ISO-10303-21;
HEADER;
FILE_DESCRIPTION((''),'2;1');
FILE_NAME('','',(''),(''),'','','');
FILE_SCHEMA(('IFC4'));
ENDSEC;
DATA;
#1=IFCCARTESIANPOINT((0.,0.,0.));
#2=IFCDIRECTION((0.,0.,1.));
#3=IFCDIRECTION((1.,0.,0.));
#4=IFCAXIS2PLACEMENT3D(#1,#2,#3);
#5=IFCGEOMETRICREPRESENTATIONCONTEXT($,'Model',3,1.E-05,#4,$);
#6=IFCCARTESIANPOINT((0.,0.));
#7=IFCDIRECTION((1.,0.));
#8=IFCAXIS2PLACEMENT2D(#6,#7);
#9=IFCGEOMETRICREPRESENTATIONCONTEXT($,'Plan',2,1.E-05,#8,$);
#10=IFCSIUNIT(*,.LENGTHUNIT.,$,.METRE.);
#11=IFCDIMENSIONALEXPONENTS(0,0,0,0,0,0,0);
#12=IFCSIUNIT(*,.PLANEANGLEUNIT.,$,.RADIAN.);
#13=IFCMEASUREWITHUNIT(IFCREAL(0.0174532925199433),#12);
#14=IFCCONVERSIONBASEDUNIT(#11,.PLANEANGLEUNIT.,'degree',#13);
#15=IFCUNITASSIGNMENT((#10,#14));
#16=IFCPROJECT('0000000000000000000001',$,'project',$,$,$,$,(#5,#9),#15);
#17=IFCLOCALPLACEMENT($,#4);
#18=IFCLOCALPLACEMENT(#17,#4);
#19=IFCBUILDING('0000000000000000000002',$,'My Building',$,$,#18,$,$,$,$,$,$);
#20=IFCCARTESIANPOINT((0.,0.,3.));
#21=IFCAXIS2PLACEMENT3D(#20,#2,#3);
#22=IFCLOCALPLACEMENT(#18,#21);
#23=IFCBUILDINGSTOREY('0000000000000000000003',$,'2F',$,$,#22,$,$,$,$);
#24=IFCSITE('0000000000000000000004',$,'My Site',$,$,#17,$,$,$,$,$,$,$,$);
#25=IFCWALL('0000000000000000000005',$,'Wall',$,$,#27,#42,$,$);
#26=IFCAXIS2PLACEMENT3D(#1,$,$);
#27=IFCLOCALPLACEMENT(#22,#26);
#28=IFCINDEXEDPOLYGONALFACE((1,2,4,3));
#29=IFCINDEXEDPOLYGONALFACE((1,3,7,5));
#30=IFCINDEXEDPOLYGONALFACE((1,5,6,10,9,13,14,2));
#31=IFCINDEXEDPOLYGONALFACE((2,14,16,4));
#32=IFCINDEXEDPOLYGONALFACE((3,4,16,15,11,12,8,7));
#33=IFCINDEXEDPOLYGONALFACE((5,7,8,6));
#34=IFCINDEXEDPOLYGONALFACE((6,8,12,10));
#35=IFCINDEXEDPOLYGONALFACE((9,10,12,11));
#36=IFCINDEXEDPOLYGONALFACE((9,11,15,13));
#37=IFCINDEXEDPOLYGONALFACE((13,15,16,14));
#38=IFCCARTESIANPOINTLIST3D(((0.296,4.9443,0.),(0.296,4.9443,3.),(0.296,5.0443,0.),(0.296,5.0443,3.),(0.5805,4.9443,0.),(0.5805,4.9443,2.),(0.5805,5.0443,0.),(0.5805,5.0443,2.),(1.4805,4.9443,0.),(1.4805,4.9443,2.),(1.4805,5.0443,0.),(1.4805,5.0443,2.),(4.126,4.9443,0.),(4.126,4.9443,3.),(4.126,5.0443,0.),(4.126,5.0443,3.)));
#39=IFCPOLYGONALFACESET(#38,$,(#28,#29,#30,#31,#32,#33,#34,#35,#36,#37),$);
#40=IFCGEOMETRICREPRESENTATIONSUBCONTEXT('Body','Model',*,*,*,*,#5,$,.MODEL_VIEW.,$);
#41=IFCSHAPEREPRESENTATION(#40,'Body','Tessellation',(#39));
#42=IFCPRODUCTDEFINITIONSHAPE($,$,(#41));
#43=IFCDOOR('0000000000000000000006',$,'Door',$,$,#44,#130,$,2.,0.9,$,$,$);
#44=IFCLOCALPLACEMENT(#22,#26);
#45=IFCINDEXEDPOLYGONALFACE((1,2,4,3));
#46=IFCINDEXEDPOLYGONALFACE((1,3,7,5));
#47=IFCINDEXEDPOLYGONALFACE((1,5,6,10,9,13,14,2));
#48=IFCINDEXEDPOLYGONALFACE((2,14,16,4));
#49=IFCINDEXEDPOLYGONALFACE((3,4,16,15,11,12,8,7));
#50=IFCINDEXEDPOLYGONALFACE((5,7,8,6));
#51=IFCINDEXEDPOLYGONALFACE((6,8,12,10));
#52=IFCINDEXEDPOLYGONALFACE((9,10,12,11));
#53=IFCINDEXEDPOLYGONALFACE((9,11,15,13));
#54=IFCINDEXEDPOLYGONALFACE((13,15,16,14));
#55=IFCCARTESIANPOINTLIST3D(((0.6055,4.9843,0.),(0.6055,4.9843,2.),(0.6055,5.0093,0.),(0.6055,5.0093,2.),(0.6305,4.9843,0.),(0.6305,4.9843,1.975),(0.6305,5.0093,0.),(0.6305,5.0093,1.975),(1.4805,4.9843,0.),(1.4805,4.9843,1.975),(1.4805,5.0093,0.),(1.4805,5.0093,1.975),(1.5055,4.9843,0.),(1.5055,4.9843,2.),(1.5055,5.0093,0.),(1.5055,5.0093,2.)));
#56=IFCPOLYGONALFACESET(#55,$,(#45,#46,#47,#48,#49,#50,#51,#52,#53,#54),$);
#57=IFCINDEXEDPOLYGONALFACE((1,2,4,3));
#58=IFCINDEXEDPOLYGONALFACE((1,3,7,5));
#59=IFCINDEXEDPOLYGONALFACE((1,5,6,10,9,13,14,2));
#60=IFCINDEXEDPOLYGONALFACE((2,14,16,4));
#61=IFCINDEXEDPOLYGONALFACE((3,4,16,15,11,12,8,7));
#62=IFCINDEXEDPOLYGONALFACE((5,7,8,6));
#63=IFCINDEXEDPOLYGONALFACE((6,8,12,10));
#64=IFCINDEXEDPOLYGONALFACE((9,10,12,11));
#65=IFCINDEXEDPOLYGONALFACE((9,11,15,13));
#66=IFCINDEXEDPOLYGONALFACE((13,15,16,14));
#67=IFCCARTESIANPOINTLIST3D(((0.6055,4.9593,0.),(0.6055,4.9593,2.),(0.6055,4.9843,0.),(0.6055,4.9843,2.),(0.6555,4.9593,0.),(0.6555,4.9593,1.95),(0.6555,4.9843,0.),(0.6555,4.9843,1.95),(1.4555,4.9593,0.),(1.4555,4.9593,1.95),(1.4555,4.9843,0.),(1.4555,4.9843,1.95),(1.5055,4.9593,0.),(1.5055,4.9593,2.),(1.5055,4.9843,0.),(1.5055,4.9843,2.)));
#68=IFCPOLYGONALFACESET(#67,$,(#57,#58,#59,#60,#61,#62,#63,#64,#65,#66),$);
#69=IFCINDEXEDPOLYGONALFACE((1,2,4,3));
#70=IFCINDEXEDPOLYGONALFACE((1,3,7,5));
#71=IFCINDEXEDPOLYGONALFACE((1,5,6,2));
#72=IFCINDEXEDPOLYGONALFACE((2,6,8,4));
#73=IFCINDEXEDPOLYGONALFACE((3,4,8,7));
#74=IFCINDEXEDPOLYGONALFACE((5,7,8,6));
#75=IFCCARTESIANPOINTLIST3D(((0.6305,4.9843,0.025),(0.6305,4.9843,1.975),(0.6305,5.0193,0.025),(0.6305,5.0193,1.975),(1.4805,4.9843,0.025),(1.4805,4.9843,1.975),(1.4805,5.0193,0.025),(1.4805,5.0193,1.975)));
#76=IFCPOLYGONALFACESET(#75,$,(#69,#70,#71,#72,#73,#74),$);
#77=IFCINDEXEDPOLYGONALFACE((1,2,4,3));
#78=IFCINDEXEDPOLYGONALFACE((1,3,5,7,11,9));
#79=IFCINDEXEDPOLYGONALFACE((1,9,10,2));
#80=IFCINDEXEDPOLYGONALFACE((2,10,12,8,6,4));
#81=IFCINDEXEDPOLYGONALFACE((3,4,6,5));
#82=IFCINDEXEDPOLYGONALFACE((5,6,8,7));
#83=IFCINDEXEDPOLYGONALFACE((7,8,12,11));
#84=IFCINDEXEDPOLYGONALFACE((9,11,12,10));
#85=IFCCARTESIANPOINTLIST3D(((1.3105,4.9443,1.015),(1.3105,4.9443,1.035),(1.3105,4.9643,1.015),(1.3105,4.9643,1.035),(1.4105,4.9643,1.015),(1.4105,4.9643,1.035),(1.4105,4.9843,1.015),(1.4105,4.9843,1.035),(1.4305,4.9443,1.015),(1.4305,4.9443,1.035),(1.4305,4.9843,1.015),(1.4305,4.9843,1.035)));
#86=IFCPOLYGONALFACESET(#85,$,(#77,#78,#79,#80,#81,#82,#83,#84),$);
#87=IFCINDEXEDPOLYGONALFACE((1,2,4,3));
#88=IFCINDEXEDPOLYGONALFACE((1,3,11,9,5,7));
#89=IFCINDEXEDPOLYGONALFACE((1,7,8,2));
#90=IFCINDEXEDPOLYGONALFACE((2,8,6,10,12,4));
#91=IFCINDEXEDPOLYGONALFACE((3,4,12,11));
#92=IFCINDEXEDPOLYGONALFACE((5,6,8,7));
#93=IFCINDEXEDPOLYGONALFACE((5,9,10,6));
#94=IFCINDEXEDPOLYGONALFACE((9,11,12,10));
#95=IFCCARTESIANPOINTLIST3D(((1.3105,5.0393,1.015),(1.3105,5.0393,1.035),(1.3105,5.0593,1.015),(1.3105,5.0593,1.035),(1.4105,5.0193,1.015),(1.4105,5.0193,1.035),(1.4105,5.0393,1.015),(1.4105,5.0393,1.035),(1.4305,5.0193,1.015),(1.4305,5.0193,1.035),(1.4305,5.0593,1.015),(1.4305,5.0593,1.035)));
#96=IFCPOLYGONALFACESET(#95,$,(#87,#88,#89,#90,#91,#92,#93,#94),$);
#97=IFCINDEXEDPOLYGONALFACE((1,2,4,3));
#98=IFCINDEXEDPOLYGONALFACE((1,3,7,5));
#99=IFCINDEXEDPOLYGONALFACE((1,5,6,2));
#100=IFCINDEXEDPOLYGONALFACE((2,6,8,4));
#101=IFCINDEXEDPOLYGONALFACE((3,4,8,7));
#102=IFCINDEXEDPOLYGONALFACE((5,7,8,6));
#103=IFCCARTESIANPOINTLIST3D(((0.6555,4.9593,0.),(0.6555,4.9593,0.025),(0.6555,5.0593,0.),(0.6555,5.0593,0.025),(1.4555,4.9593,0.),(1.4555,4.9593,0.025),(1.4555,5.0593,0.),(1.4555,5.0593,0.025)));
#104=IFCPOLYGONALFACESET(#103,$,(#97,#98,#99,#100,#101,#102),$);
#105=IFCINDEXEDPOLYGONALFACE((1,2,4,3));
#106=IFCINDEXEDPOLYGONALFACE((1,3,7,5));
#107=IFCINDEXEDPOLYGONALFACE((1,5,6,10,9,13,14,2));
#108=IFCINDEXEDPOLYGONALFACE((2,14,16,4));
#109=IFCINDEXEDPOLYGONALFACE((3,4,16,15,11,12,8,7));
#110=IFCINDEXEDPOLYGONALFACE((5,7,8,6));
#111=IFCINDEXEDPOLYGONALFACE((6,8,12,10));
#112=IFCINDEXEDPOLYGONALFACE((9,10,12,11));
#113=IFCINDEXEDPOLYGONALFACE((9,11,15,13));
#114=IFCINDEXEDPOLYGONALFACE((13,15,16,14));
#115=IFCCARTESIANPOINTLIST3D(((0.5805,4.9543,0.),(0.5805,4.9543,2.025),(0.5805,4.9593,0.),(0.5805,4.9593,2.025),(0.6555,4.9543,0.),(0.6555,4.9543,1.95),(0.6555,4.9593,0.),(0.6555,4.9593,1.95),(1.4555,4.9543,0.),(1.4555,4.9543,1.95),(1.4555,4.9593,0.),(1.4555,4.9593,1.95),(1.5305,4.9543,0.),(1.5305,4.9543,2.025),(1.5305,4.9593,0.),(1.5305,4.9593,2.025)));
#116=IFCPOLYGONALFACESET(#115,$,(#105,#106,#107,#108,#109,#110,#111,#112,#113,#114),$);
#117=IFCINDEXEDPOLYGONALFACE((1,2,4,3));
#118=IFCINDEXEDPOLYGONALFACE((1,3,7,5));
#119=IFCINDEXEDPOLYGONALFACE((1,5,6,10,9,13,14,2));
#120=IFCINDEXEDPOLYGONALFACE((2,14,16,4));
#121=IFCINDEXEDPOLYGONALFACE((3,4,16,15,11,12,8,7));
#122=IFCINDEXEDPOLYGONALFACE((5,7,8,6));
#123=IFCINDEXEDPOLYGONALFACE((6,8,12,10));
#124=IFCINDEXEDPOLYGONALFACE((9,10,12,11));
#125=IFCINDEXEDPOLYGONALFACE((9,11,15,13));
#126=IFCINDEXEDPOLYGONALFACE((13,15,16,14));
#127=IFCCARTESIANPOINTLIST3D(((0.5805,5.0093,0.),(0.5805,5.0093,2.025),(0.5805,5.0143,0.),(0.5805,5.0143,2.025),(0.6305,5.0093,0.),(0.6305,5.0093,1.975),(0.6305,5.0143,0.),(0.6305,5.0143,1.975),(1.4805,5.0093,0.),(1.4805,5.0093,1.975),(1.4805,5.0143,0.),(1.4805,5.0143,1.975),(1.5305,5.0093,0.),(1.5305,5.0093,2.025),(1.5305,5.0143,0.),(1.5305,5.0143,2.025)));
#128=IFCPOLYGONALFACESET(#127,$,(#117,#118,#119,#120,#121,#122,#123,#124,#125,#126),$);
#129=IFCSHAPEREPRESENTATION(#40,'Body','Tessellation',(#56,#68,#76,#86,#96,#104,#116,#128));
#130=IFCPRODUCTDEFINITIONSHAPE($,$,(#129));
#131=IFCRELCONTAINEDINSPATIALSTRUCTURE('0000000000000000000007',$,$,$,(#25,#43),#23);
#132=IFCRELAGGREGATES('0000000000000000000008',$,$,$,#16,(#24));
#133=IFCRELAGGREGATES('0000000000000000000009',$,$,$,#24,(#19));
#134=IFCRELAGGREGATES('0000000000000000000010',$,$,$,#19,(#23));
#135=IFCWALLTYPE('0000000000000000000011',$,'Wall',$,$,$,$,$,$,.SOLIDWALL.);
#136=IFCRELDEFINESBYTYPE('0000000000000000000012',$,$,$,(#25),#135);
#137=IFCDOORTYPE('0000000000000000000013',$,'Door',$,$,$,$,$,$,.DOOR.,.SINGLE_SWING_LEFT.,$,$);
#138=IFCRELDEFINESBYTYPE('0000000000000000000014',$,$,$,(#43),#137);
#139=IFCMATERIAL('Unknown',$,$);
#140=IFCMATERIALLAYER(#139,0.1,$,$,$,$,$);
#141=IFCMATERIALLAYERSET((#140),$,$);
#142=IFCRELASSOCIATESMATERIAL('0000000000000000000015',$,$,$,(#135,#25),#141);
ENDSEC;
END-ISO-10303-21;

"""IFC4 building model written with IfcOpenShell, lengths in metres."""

from ifc_helpers import new_model, entity, si_unit, converted_unit, frame, origin_with_axes, origin_2d_with_axis, place, context, subcontext, project, spatial, line, indexed_curve, outline, extrude, shape, source, transform, mapped, material, layer, layer_set, layer_usage, type_object, type_shapes, element, fill, save


model = new_model("IFC4")

# Units and contexts
model_context = context("Model", 3, precision=1e-05, world=origin_with_axes())
plan_context = context("Plan", 2, precision=1e-05, world=origin_2d_with_axis())
body_context_1 = subcontext(model_context, "Body", "Model", "MODEL_VIEW")
body_context_2 = subcontext(plan_context, "Body", "Plan", "PLAN_VIEW")
ifc_project = project(units=[si_unit("LENGTHUNIT", "METRE"), converted_unit("PLANEANGLEUNIT", "degree", entity("IfcReal", 0.0174532925199433), si_unit("PLANEANGLEUNIT", "RADIAN"), dimensions=[0, 0, 0, 0, 0, 0, 0])], contexts=[model_context, plan_context])

# Site, building, storey
site_placement = place(None, origin_with_axes())
site = spatial("IfcSite", under=ifc_project, at=site_placement, Name="My Site")
building_placement = place(site_placement, origin_with_axes())
building = spatial("IfcBuilding", under=site, at=building_placement, Name="My Building")
storey_placement = place(building_placement, frame((0.0, 0.0, 3.0), z_axis=(0.0, 0.0, 1.0), x_axis=(1.0, 0.0, 0.0)))
storey = spatial("IfcBuildingStorey", under=building, at=storey_placement, Name="2F")

# Shared definitions
ifc_material = material(Name="Unknown")

# Shared definitions
ifc_layer = layer(ifc_material, 0.1)
ifc_layer_set = layer_set([ifc_layer])
wall_type = type_object("IfcWallType", Name="Wall", PredefinedType="SOLIDWALL", material=ifc_layer_set)

# Wall, opening, door
shared_shape_1 = source(origin_with_axes(), body_context_1, "Body", "SweptSolid", [
    extrude(outline(indexed_curve([(0.0, 0.0), (0.9, 0.0), (0.9, 2.0), (0.0, 2.0)], segments=[line(1, 2, 3, 4, 1)])), frame((0.0, -0.6, 0.0), z_axis=(0.0, -1.0, 0.0), x_axis=(1.0, 0.0, 0.0)), (0.0, 0.0, -1.0), 1.2),
])
door_type = type_object("IfcDoorType", Name="Door", OperationType="SINGLE_SWING_LEFT", PredefinedType="DOOR")
shared_shape_2 = source(origin_with_axes(), body_context_1, "Body", "SweptSolid", [
    extrude(outline(indexed_curve([(0.0, 0.0), (0.0, 2.0), (0.9, 2.0), (0.9, 0.0), (0.875, 0.0), (0.875, 1.975), (0.025, 1.975), (0.025, 0.0)], segments=[line(1, 2, 3, 4, 5, 6, 7, 8, 1)])), frame((0.0, 0.025, 0.0), z_axis=(0.0, -1.0, 0.0), x_axis=(1.0, 0.0, 0.0)), (0.0, 0.0, -1.0), 0.025),
    extrude(outline(indexed_curve([(0.0, 0.0), (0.0, 2.0), (0.9, 2.0), (0.9, 0.0), (0.85, 0.0), (0.85, 1.95), (0.05, 1.95), (0.05, 0.0)], segments=[line(1, 2, 3, 4, 5, 6, 7, 8, 1)])), frame((0.0, 0.0, 0.0), z_axis=(0.0, -1.0, 0.0), x_axis=(1.0, 0.0, 0.0)), (0.0, 0.0, -1.0), 0.025),
    extrude(outline(indexed_curve([(0.0, 0.0), (0.85, 0.0), (0.85, 0.035), (0.0, 0.035)], segments=[line(1, 2, 3, 4, 1)])), frame((0.025, 0.025, 0.025), z_axis=(0.0, 0.0, 1.0), x_axis=(1.0, 0.0, 0.0)), (0.0, 0.0, 1.0), 1.95),
    extrude(outline(indexed_curve([(0.0, 0.0), (0.0, -0.04), (-0.12, -0.04), (-0.12, -0.02), (-0.02, -0.02), (-0.02, 0.0)], segments=[line(1, 2, 3, 4, 5, 6, 1)])), frame((0.825, 0.025, 1.015), z_axis=(0.0, 0.0, 1.0), x_axis=(1.0, 0.0, 0.0)), (0.0, 0.0, 1.0), 0.02),
    extrude(outline(indexed_curve([(0.0, 0.0), (0.0, 0.04), (-0.12, 0.04), (-0.12, 0.02), (-0.02, 0.02), (-0.02, 0.0)], segments=[line(1, 2, 3, 4, 5, 6, 1)])), frame((0.825, 0.06, 1.015), z_axis=(0.0, 0.0, 1.0), x_axis=(1.0, 0.0, 0.0)), (0.0, 0.0, 1.0), 0.02),
    extrude(outline(indexed_curve([(0.0, 0.0), (0.8, 0.0), (0.8, 0.1), (0.0, 0.1)], segments=[line(1, 2, 3, 4, 1)])), frame((0.05, 0.0, 0.0), z_axis=(0.0, 0.0, 1.0), x_axis=(1.0, 0.0, 0.0)), (0.0, 0.0, 1.0), 0.025),
    extrude(outline(indexed_curve([(0.0, 0.0), (0.0, 2.025), (0.95, 2.025), (0.95, 0.0), (0.875, 0.0), (0.875, 1.95), (0.075, 1.95), (0.075, 0.0)], segments=[line(1, 2, 3, 4, 5, 6, 7, 8, 1)])), frame((-0.025, -0.005, 0.0), z_axis=(0.0, -1.0, 0.0), x_axis=(1.0, 0.0, 0.0)), (0.0, 0.0, -1.0), 0.005),
    extrude(outline(indexed_curve([(0.0, 0.0), (0.0, 2.025), (0.95, 2.025), (0.95, 0.0), (0.9, 0.0), (0.9, 1.975), (0.05, 1.975), (0.05, 0.0)], segments=[line(1, 2, 3, 4, 5, 6, 7, 8, 1)])), frame((-0.025, 0.05, 0.0), z_axis=(0.0, -1.0, 0.0), x_axis=(1.0, 0.0, 0.0)), (0.0, 0.0, -1.0), 0.005),
])
shared_shape_3 = source(origin_with_axes(), body_context_2, "Body", "Curve2D", [
    entity("IfcIndexedPolyCurve", entity("IfcCartesianPointList2D", [[0.0, 0.0], [0.0, 0.05], [0.025, 0.05], [0.025, 0.025], [0.05, 0.025], [0.05, 0.0]]), [entity("IfcLineIndex", [1, 2, 3, 4, 5, 6, 1])]),
    entity("IfcIndexedPolyCurve", entity("IfcCartesianPointList2D", [[0.9, 0.0], [0.9, 0.05], [0.875, 0.05], [0.875, 0.025], [0.85, 0.025], [0.85, 0.0]]), [entity("IfcLineIndex", [1, 2, 3, 4, 5, 6, 1])]),
    entity("IfcTrimmedCurve", entity("IfcEllipse", entity("IfcAxis2Placement2D", entity("IfcCartesianPoint", [0.06, 0.05]), entity("IfcDirection", [1.0, 0.0])), 0.815, 0.85), [entity("IfcCartesianPoint", [0.875, 0.05])], [entity("IfcCartesianPoint", [0.06, 0.9])], True, "CARTESIAN"),
    entity("IfcIndexedPolyCurve", entity("IfcCartesianPointList2D", [[0.025, 0.05], [0.06, 0.05], [0.06, 0.9], [0.025, 0.9]]), [entity("IfcLineIndex", [1, 2, 3, 4, 1])]),
])
type_shapes(door_type, [shared_shape_2, shared_shape_3])
ifc_layer_usage_1 = layer_usage(ifc_layer_set, "AXIS2", "POSITIVE", 0.0)
wall_1_placement = place(storey_placement, frame((4.126, 5.0443, 0.0), z_axis=(0.0, 0.0, 1.0), x_axis=(-1.0, -0.000001, 0.0)))
wall_1 = element("IfcWall", 1, at=wall_1_placement, inside=storey, type_object=wall_type, material=ifc_layer_usage_1, Name="Wall", context=body_context_1, shape_type="SweptSolid", body=[
    extrude(outline(indexed_curve([(0.0, 0.0), (0.0, 0.1), (3.83, 0.1), (3.83, 0.0)], segments=[line(1, 2, 3, 4, 1)])), origin_with_axes(), (0.0, 0.0, 1.0), 3.0),
])
opening_1_placement = place(wall_1_placement, frame((2.6455, 0.0, 0.0), z_axis=(0.0, 0.0, 1.0), x_axis=(1.0, 0.0, 0.0)))
opening_1 = element("IfcOpeningElement", 2, at=opening_1_placement, cuts=wall_1, PredefinedType="OPENING", context=body_context_1, shape_type="MappedRepresentation", body=[
    mapped(shared_shape_1, transform((0.0, 0.0, 0.0), x_axis=(1.0, 0.0, 0.0), y_axis=(0.0, 1.0, 0.0), z_axis=(0.0, 0.0, 1.0), scale=1.0)),
])
door_1_placement = place(opening_1_placement, frame((0.875, 0.085, 0.0), z_axis=(0.0, 0.0, 1.0), x_axis=(-1.0, 0.0, 0.0)))
door_1 = element("IfcDoor", 3, at=door_1_placement, inside=storey, type_object=door_type, Name="Door", OverallHeight=2.0, OverallWidth=0.9, shapes=[
    shape(body_context_1, "Body", "MappedRepresentation", [mapped(shared_shape_2, transform((0.0, 0.0, 0.0), x_axis=(1.0, 0.0, 0.0), y_axis=(0.0, 1.0, 0.0), z_axis=(0.0, 0.0, 1.0), scale=1.0))]),
    shape(body_context_2, "Body", "MappedRepresentation", [mapped(shared_shape_3, transform((0.0, 0.0, 0.0), x_axis=(1.0, 0.0, 0.0), y_axis=(0.0, 1.0, 0.0), z_axis=(0.0, 0.0, 1.0), scale=1.0))]),
])
fill(opening_1, door_1)

save(model, "model.ifc")
